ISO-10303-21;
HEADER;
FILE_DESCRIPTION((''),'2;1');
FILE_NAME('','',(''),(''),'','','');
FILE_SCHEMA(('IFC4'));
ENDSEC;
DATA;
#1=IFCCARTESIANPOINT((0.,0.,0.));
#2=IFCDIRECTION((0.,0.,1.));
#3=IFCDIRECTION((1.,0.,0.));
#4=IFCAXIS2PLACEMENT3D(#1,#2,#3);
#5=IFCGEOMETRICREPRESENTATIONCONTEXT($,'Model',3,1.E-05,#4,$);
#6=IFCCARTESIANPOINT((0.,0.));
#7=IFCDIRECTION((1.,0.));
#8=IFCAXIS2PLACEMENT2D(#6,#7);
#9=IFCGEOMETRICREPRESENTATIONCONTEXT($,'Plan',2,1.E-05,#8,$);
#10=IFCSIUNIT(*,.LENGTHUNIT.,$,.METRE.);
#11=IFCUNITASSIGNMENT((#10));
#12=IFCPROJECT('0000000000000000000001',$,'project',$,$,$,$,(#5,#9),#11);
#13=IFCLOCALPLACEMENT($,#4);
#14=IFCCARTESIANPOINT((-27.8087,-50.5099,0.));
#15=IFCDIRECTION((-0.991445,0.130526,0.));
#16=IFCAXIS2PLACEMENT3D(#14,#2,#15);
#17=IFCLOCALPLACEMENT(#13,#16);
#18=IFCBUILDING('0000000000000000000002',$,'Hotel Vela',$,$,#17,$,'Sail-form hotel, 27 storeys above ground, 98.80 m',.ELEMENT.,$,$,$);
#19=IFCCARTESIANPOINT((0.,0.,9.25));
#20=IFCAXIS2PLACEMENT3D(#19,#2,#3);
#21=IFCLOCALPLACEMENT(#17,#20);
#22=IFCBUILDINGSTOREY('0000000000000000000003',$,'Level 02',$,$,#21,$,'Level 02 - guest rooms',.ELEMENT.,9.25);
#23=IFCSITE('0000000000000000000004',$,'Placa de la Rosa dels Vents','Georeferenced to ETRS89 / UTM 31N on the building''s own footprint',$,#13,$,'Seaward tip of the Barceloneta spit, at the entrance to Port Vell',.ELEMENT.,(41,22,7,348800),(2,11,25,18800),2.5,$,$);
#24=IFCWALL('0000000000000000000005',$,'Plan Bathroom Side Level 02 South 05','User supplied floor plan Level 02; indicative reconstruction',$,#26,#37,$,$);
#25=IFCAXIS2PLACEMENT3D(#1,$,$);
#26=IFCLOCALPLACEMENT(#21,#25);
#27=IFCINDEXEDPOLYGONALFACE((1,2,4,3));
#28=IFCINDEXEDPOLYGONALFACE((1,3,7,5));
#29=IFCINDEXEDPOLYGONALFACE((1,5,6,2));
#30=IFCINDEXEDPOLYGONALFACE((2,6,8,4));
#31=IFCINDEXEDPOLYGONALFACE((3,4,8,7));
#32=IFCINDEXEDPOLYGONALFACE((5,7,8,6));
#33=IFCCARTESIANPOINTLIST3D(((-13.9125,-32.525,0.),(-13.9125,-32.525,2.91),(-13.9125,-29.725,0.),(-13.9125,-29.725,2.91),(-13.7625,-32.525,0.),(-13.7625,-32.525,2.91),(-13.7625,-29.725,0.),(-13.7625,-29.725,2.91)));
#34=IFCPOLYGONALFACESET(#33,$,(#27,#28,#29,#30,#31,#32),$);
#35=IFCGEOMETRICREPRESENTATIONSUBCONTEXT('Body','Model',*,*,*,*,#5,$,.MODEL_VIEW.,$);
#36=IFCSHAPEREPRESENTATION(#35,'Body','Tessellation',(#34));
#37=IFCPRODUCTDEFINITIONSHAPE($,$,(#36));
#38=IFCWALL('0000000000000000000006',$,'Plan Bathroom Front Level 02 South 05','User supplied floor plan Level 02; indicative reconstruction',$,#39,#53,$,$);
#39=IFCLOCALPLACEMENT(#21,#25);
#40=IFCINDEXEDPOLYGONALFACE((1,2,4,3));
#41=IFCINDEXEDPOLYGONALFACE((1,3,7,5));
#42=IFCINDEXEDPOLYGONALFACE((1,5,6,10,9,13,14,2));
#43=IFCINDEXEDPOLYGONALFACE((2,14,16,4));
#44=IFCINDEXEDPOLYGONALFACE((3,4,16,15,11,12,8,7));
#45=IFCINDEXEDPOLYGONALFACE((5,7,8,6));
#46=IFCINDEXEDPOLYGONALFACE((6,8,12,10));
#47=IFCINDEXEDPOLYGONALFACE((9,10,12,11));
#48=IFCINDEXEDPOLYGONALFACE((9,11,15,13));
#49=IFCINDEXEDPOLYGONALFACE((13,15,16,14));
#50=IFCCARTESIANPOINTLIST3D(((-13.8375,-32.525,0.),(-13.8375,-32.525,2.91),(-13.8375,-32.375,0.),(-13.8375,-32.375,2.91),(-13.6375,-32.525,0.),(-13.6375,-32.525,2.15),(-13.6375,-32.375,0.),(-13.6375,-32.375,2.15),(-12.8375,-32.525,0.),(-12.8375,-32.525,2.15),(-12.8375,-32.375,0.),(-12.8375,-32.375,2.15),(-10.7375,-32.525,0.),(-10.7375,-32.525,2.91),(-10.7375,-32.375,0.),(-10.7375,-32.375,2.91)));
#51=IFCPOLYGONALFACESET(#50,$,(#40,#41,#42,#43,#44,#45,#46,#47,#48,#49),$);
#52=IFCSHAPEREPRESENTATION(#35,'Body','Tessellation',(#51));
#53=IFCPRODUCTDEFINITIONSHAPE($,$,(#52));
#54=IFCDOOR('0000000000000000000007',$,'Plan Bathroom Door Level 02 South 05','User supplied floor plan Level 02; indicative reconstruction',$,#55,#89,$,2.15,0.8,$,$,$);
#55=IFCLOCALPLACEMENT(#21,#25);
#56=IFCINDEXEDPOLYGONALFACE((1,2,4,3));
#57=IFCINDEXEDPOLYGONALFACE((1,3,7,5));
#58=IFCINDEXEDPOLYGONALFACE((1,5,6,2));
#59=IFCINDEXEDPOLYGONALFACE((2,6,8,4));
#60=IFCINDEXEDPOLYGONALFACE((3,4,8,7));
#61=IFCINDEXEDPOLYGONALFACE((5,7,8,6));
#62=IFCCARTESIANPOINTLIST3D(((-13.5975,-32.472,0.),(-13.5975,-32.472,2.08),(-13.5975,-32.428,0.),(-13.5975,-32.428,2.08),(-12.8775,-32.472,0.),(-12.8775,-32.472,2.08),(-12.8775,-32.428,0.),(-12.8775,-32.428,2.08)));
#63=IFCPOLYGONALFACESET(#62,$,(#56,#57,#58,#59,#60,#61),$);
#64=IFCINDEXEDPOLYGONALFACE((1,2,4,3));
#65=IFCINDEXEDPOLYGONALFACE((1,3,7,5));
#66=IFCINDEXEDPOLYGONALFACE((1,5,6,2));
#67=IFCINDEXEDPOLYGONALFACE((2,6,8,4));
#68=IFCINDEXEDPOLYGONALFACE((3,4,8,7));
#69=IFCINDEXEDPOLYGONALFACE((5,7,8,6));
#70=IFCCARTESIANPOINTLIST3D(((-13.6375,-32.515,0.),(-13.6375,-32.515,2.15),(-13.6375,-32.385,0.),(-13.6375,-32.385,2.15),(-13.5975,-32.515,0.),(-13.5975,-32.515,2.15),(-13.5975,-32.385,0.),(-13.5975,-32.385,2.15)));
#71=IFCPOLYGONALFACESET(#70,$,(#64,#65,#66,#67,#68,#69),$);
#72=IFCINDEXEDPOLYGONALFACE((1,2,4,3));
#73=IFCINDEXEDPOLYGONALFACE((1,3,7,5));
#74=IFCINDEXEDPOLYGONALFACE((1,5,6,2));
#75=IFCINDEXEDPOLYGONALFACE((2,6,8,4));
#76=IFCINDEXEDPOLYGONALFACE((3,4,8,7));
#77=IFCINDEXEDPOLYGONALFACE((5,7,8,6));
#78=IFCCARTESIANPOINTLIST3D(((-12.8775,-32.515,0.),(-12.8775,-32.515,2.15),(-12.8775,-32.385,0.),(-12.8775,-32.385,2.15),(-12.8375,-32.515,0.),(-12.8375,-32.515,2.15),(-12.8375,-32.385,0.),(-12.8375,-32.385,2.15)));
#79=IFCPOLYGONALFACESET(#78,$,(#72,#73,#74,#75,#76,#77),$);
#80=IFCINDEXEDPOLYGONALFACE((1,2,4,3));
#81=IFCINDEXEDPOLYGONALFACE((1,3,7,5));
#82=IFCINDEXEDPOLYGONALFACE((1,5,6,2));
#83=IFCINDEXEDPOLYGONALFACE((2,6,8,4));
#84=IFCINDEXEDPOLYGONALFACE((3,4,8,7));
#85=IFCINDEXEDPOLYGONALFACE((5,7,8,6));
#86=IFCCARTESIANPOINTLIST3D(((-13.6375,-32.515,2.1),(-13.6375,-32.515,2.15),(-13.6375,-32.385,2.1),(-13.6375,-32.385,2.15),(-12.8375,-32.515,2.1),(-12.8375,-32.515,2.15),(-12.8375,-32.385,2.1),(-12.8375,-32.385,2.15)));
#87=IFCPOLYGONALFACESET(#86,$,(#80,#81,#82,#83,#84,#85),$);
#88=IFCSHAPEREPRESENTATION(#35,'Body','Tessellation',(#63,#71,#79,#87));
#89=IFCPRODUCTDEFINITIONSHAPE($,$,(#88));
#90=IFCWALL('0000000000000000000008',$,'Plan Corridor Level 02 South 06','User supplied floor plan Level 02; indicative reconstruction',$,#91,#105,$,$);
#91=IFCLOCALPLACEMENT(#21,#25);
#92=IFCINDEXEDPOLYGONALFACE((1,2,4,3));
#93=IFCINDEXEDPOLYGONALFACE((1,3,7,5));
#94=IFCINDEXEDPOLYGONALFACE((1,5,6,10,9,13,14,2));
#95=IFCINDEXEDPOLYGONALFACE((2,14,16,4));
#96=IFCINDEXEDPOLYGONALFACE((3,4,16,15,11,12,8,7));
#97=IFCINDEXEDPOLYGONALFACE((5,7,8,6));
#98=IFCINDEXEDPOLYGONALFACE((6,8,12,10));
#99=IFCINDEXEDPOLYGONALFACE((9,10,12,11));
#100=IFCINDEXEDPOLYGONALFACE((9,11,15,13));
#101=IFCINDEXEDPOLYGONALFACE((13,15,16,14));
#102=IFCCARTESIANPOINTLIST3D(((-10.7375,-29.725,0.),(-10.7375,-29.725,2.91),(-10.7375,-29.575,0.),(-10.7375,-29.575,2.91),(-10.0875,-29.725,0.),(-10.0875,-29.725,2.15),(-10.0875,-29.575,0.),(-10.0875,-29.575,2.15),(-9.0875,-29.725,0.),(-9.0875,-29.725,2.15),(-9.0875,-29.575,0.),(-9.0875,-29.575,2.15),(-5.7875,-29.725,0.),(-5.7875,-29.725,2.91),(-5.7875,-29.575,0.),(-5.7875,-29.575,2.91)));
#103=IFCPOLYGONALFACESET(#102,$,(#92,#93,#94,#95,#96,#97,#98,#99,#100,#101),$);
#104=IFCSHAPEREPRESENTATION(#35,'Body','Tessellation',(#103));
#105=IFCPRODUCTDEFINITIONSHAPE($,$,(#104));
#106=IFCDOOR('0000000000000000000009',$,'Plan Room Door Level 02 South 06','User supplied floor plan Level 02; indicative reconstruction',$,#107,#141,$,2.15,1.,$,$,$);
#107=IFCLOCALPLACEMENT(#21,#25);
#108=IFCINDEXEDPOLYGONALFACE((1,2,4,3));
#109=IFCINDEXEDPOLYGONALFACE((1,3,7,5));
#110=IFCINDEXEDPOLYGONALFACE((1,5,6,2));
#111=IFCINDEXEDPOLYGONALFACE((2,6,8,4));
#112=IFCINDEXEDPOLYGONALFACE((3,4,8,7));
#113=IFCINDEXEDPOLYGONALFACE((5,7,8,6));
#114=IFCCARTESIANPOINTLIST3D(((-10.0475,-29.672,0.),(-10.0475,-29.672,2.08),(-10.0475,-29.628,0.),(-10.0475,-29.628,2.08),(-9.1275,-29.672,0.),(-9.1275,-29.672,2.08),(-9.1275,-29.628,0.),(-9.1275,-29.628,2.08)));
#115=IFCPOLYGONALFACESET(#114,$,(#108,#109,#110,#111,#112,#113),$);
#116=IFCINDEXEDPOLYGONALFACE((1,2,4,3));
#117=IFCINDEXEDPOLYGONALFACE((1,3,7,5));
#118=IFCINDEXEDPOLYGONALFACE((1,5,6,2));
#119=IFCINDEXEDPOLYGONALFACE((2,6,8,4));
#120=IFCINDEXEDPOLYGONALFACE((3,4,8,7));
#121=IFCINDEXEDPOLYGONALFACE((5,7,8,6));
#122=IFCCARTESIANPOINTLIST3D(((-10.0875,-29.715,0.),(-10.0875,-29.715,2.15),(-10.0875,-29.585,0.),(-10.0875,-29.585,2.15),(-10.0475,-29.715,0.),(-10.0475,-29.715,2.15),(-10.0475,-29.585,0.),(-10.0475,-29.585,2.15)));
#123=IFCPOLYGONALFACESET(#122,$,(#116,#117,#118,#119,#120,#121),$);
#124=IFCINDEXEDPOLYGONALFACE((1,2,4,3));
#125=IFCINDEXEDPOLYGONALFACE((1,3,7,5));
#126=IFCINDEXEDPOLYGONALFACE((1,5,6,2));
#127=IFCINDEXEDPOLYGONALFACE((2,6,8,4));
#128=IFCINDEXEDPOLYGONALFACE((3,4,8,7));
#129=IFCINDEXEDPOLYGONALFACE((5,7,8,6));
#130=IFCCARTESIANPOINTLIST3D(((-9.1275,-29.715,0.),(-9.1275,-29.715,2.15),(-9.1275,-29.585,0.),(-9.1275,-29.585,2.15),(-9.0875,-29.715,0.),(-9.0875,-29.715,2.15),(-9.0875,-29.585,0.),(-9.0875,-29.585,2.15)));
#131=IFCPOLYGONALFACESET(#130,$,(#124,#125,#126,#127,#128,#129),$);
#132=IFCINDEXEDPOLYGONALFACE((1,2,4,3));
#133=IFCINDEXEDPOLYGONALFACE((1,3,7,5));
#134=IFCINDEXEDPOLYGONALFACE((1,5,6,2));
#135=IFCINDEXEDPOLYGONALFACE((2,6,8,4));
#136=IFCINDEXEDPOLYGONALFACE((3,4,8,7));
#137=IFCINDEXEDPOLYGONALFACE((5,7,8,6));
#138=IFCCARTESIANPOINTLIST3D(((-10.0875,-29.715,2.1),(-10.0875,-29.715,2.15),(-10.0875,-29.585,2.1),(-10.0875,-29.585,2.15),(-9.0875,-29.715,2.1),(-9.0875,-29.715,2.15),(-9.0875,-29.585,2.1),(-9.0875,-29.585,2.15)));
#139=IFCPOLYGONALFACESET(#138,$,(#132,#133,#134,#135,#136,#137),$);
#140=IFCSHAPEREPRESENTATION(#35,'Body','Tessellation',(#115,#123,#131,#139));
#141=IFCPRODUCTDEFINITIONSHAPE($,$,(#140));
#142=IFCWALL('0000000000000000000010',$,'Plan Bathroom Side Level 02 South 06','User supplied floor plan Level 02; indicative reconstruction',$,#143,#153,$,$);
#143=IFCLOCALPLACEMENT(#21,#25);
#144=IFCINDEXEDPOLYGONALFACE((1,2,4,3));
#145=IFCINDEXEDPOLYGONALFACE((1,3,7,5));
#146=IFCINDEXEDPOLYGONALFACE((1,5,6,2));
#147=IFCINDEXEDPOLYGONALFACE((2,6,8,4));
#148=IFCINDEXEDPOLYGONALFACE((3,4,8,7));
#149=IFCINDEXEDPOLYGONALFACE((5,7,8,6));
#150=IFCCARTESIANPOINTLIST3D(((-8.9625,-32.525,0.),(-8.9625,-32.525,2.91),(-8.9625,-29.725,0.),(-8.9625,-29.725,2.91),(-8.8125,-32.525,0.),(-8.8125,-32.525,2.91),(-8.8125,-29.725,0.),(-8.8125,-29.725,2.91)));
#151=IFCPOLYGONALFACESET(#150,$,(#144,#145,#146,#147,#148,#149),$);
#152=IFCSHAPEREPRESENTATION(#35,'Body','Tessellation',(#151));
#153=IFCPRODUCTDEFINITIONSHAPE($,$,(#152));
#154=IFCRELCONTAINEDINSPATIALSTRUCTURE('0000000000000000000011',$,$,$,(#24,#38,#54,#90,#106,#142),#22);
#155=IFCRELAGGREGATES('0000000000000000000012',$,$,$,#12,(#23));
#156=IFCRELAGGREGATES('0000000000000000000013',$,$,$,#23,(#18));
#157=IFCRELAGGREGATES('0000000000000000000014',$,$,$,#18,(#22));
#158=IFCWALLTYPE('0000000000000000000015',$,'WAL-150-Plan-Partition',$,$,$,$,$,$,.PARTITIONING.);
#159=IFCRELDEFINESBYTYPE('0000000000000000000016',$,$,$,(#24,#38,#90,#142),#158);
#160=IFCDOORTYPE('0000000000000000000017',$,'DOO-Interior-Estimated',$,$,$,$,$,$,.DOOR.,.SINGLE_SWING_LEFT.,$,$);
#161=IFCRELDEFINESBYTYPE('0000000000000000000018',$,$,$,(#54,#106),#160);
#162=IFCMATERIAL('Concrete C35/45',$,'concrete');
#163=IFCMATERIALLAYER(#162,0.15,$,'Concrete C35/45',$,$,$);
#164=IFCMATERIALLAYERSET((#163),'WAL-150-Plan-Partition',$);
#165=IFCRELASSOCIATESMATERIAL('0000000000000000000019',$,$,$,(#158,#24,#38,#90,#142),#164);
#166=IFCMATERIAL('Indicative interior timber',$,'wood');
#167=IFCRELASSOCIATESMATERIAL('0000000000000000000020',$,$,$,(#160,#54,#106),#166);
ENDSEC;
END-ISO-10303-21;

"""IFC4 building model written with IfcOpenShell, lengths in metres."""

from ifc_helpers import new_model, si_unit, frame, origin_with_axes, origin_2d_with_axis, place, context, subcontext, project, spatial, line, indexed_curve, outline, extrude, material, layer, layer_set, layer_usage, type_object, element, fill, save


model = new_model("IFC4")

# Units and contexts
model_context = context("Model", 3, precision=1e-05, world=origin_with_axes())
plan_context = context("Plan", 2, precision=1e-05, world=origin_2d_with_axis())
body_context = subcontext(model_context, "Body", "Model", "MODEL_VIEW")
ifc_project = project(units=[si_unit("LENGTHUNIT", "METRE")], contexts=[model_context, plan_context])

# Site, building, storey
site_placement = place(None, origin_with_axes())
site = spatial("IfcSite", under=ifc_project, at=site_placement, Name="Placa de la Rosa dels Vents", Description="Georeferenced to ETRS89 / UTM 31N on the building's own footprint", LongName="Seaward tip of the Barceloneta spit, at the entrance to Port Vell", CompositionType="ELEMENT", RefLatitude=(41, 22, 7, 348800), RefLongitude=(2, 11, 25, 18800), RefElevation=2.5)
building_placement = place(site_placement, frame((-27.8087, -50.5099, 0.0), z_axis=(0.0, 0.0, 1.0), x_axis=(-0.991445, 0.130526, 0.0)))
building = spatial("IfcBuilding", under=site, at=building_placement, Name="Hotel Vela", LongName="Sail-form hotel, 27 storeys above ground, 98.80 m", CompositionType="ELEMENT")
storey_placement = place(building_placement, frame((0.0, 0.0, 9.25), z_axis=(0.0, 0.0, 1.0), x_axis=(1.0, 0.0, 0.0)))
storey = spatial("IfcBuildingStorey", under=building, at=storey_placement, Name="Level 02", LongName="Level 02 - guest rooms", CompositionType="ELEMENT", Elevation=9.25)

# Wall
ifc_material_1 = material(Name="Concrete C35/45", Category="concrete")
ifc_layer = layer(ifc_material_1, 0.15, Name="Concrete C35/45")
ifc_layer_set = layer_set([ifc_layer], Name="WAL-150-Plan-Partition")
ifc_layer_usage_1 = layer_usage(ifc_layer_set, "AXIS2", "POSITIVE", 0.0)
wall_type = type_object("IfcWallType", Name="WAL-150-Plan-Partition", PredefinedType="PARTITIONING", material=ifc_layer_set)
wall_1_placement = place(storey_placement, frame((-13.9125, -32.525, 0.0), z_axis=(0.0, 0.0, 1.0), x_axis=(1.0, 0.0, 0.0)))
element("IfcWall", 1, at=wall_1_placement, inside=storey, type_object=wall_type, material=ifc_layer_usage_1, Name="Plan Bathroom Side Level 02 South 05", Description="User supplied floor plan Level 02; indicative reconstruction", context=body_context, shape_type="SweptSolid", body=[
    extrude(outline(indexed_curve([(0.0, 0.0), (0.15, 0.0), (0.15, 2.8), (0.0, 2.8)], segments=[line(1, 2, 3, 4, 1)])), origin_with_axes(), (0.0, 0.0, 1.0), 2.91),
])

# Walls, openings, doors
ifc_layer_usage_2 = layer_usage(ifc_layer_set, "AXIS2", "POSITIVE", 0.0)
wall_2_placement = place(storey_placement, frame((-13.8375, -32.525, 0.0), z_axis=(0.0, 0.0, 1.0), x_axis=(1.0, 0.0, 0.0)))
wall_2 = element("IfcWall", 2, at=wall_2_placement, inside=storey, type_object=wall_type, material=ifc_layer_usage_2, Name="Plan Bathroom Front Level 02 South 05", Description="User supplied floor plan Level 02; indicative reconstruction", context=body_context, shape_type="SweptSolid", body=[
    extrude(outline(indexed_curve([(0.0, 0.0), (3.1, 0.0), (3.1, 0.15), (0.0, 0.15)], segments=[line(1, 2, 3, 4, 1)])), origin_with_axes(), (0.0, 0.0, 1.0), 2.91),
])
opening_1_placement = place(wall_2_placement, frame((0.2, -0.085, 0.0), z_axis=(0.0, 0.0, 1.0), x_axis=(1.0, 0.0, 0.0)))
opening_1 = element("IfcOpeningElement", 3, at=opening_1_placement, cuts=wall_2, PredefinedType="OPENING", context=body_context, shape_type="SweptSolid", body=[
    extrude(outline(indexed_curve([(0.0, 0.0), (0.8, 0.0), (0.8, 0.32), (0.0, 0.32)], segments=[line(1, 2, 3, 4, 1)])), origin_with_axes(), (0.0, 0.0, 1.0), 2.15),
])
ifc_material_2 = material(Name="Indicative interior timber", Category="wood")
door_type = type_object("IfcDoorType", Name="DOO-Interior-Estimated", OperationType="SINGLE_SWING_LEFT", PredefinedType="DOOR", material=ifc_material_2)
door_1_placement = place(storey_placement, frame((0.0, 0.0, -9.25), z_axis=(0.0, 0.0, 1.0), x_axis=(1.0, 0.0, 0.0)))
door_1 = element("IfcDoor", 4, at=door_1_placement, inside=storey, type_object=door_type, material=ifc_material_2, Name="Plan Bathroom Door Level 02 South 05", Description="User supplied floor plan Level 02; indicative reconstruction", OverallHeight=2.15, OverallWidth=0.8, context=body_context, shape_type="SweptSolid", body=[
    extrude(outline(indexed_curve([(0.0, 0.0), (0.72, 0.0), (0.72, 0.044), (0.0, 0.044)], segments=[line(1, 2, 3, 4, 1)])), frame((-13.5975, -32.472, 9.25), z_axis=(0.0, 0.0, 1.0), x_axis=(1.0, 0.0, 0.0)), (0.0, 0.0, 1.0), 2.08),
    extrude(outline(indexed_curve([(0.0, 0.0), (0.04, 0.0), (0.04, 0.13), (0.0, 0.13)], segments=[line(1, 2, 3, 4, 1)])), frame((-13.6375, -32.515, 9.25), z_axis=(0.0, 0.0, 1.0), x_axis=(1.0, 0.0, 0.0)), (0.0, 0.0, 1.0), 2.15),
    extrude(outline(indexed_curve([(0.0, 0.0), (0.04, 0.0), (0.04, 0.13), (0.0, 0.13)], segments=[line(1, 2, 3, 4, 1)])), frame((-12.8775, -32.515, 9.25), z_axis=(0.0, 0.0, 1.0), x_axis=(1.0, 0.0, 0.0)), (0.0, 0.0, 1.0), 2.15),
    extrude(outline(indexed_curve([(0.0, 0.0), (0.8, 0.0), (0.8, 0.13), (0.0, 0.13)], segments=[line(1, 2, 3, 4, 1)])), frame((-13.6375, -32.515, 11.35), z_axis=(0.0, 0.0, 1.0), x_axis=(1.0, 0.0, 0.0)), (0.0, 0.0, 1.0), 0.05),
])
fill(opening_1, door_1)
ifc_layer_usage_3 = layer_usage(ifc_layer_set, "AXIS2", "POSITIVE", 0.0)
wall_3_placement = place(storey_placement, frame((-10.7375, -29.725, 0.0), z_axis=(0.0, 0.0, 1.0), x_axis=(1.0, 0.0, 0.0)))
wall_3 = element("IfcWall", 5, at=wall_3_placement, inside=storey, type_object=wall_type, material=ifc_layer_usage_3, Name="Plan Corridor Level 02 South 06", Description="User supplied floor plan Level 02; indicative reconstruction", context=body_context, shape_type="SweptSolid", body=[
    extrude(outline(indexed_curve([(0.0, 0.0), (4.95, 0.0), (4.95, 0.15), (0.0, 0.15)], segments=[line(1, 2, 3, 4, 1)])), origin_with_axes(), (0.0, 0.0, 1.0), 2.91),
])
opening_2_placement = place(wall_3_placement, frame((0.65, -0.085, 0.0), z_axis=(0.0, 0.0, 1.0), x_axis=(1.0, 0.0, 0.0)))
opening_2 = element("IfcOpeningElement", 6, at=opening_2_placement, cuts=wall_3, PredefinedType="OPENING", context=body_context, shape_type="SweptSolid", body=[
    extrude(outline(indexed_curve([(0.0, 0.0), (1.0, 0.0), (1.0, 0.32), (0.0, 0.32)], segments=[line(1, 2, 3, 4, 1)])), origin_with_axes(), (0.0, 0.0, 1.0), 2.15),
])
door_2_placement = place(storey_placement, frame((0.0, 0.0, -9.25), z_axis=(0.0, 0.0, 1.0), x_axis=(1.0, 0.0, 0.0)))
door_2 = element("IfcDoor", 7, at=door_2_placement, inside=storey, type_object=door_type, material=ifc_material_2, Name="Plan Room Door Level 02 South 06", Description="User supplied floor plan Level 02; indicative reconstruction", OverallHeight=2.15, OverallWidth=1.0, context=body_context, shape_type="SweptSolid", body=[
    extrude(outline(indexed_curve([(0.0, 0.0), (0.92, 0.0), (0.92, 0.044), (0.0, 0.044)], segments=[line(1, 2, 3, 4, 1)])), frame((-10.0475, -29.672, 9.25), z_axis=(0.0, 0.0, 1.0), x_axis=(1.0, 0.0, 0.0)), (0.0, 0.0, 1.0), 2.08),
    extrude(outline(indexed_curve([(0.0, 0.0), (0.04, 0.0), (0.04, 0.13), (0.0, 0.13)], segments=[line(1, 2, 3, 4, 1)])), frame((-10.0875, -29.715, 9.25), z_axis=(0.0, 0.0, 1.0), x_axis=(1.0, 0.0, 0.0)), (0.0, 0.0, 1.0), 2.15),
    extrude(outline(indexed_curve([(0.0, 0.0), (0.04, 0.0), (0.04, 0.13), (0.0, 0.13)], segments=[line(1, 2, 3, 4, 1)])), frame((-9.1275, -29.715, 9.25), z_axis=(0.0, 0.0, 1.0), x_axis=(1.0, 0.0, 0.0)), (0.0, 0.0, 1.0), 2.15),
    extrude(outline(indexed_curve([(0.0, 0.0), (1.0, 0.0), (1.0, 0.13), (0.0, 0.13)], segments=[line(1, 2, 3, 4, 1)])), frame((-10.0875, -29.715, 11.35), z_axis=(0.0, 0.0, 1.0), x_axis=(1.0, 0.0, 0.0)), (0.0, 0.0, 1.0), 0.05),
])
fill(opening_2, door_2)

# Wall
ifc_layer_usage_4 = layer_usage(ifc_layer_set, "AXIS2", "POSITIVE", 0.0)
wall_4_placement = place(storey_placement, frame((-8.9625, -32.525, 0.0), z_axis=(0.0, 0.0, 1.0), x_axis=(1.0, 0.0, 0.0)))
element("IfcWall", 8, at=wall_4_placement, inside=storey, type_object=wall_type, material=ifc_layer_usage_4, Name="Plan Bathroom Side Level 02 South 06", Description="User supplied floor plan Level 02; indicative reconstruction", context=body_context, shape_type="SweptSolid", body=[
    extrude(outline(indexed_curve([(0.0, 0.0), (0.15, 0.0), (0.15, 2.8), (0.0, 2.8)], segments=[line(1, 2, 3, 4, 1)])), origin_with_axes(), (0.0, 0.0, 1.0), 2.91),
])

save(model, "model.ifc")
